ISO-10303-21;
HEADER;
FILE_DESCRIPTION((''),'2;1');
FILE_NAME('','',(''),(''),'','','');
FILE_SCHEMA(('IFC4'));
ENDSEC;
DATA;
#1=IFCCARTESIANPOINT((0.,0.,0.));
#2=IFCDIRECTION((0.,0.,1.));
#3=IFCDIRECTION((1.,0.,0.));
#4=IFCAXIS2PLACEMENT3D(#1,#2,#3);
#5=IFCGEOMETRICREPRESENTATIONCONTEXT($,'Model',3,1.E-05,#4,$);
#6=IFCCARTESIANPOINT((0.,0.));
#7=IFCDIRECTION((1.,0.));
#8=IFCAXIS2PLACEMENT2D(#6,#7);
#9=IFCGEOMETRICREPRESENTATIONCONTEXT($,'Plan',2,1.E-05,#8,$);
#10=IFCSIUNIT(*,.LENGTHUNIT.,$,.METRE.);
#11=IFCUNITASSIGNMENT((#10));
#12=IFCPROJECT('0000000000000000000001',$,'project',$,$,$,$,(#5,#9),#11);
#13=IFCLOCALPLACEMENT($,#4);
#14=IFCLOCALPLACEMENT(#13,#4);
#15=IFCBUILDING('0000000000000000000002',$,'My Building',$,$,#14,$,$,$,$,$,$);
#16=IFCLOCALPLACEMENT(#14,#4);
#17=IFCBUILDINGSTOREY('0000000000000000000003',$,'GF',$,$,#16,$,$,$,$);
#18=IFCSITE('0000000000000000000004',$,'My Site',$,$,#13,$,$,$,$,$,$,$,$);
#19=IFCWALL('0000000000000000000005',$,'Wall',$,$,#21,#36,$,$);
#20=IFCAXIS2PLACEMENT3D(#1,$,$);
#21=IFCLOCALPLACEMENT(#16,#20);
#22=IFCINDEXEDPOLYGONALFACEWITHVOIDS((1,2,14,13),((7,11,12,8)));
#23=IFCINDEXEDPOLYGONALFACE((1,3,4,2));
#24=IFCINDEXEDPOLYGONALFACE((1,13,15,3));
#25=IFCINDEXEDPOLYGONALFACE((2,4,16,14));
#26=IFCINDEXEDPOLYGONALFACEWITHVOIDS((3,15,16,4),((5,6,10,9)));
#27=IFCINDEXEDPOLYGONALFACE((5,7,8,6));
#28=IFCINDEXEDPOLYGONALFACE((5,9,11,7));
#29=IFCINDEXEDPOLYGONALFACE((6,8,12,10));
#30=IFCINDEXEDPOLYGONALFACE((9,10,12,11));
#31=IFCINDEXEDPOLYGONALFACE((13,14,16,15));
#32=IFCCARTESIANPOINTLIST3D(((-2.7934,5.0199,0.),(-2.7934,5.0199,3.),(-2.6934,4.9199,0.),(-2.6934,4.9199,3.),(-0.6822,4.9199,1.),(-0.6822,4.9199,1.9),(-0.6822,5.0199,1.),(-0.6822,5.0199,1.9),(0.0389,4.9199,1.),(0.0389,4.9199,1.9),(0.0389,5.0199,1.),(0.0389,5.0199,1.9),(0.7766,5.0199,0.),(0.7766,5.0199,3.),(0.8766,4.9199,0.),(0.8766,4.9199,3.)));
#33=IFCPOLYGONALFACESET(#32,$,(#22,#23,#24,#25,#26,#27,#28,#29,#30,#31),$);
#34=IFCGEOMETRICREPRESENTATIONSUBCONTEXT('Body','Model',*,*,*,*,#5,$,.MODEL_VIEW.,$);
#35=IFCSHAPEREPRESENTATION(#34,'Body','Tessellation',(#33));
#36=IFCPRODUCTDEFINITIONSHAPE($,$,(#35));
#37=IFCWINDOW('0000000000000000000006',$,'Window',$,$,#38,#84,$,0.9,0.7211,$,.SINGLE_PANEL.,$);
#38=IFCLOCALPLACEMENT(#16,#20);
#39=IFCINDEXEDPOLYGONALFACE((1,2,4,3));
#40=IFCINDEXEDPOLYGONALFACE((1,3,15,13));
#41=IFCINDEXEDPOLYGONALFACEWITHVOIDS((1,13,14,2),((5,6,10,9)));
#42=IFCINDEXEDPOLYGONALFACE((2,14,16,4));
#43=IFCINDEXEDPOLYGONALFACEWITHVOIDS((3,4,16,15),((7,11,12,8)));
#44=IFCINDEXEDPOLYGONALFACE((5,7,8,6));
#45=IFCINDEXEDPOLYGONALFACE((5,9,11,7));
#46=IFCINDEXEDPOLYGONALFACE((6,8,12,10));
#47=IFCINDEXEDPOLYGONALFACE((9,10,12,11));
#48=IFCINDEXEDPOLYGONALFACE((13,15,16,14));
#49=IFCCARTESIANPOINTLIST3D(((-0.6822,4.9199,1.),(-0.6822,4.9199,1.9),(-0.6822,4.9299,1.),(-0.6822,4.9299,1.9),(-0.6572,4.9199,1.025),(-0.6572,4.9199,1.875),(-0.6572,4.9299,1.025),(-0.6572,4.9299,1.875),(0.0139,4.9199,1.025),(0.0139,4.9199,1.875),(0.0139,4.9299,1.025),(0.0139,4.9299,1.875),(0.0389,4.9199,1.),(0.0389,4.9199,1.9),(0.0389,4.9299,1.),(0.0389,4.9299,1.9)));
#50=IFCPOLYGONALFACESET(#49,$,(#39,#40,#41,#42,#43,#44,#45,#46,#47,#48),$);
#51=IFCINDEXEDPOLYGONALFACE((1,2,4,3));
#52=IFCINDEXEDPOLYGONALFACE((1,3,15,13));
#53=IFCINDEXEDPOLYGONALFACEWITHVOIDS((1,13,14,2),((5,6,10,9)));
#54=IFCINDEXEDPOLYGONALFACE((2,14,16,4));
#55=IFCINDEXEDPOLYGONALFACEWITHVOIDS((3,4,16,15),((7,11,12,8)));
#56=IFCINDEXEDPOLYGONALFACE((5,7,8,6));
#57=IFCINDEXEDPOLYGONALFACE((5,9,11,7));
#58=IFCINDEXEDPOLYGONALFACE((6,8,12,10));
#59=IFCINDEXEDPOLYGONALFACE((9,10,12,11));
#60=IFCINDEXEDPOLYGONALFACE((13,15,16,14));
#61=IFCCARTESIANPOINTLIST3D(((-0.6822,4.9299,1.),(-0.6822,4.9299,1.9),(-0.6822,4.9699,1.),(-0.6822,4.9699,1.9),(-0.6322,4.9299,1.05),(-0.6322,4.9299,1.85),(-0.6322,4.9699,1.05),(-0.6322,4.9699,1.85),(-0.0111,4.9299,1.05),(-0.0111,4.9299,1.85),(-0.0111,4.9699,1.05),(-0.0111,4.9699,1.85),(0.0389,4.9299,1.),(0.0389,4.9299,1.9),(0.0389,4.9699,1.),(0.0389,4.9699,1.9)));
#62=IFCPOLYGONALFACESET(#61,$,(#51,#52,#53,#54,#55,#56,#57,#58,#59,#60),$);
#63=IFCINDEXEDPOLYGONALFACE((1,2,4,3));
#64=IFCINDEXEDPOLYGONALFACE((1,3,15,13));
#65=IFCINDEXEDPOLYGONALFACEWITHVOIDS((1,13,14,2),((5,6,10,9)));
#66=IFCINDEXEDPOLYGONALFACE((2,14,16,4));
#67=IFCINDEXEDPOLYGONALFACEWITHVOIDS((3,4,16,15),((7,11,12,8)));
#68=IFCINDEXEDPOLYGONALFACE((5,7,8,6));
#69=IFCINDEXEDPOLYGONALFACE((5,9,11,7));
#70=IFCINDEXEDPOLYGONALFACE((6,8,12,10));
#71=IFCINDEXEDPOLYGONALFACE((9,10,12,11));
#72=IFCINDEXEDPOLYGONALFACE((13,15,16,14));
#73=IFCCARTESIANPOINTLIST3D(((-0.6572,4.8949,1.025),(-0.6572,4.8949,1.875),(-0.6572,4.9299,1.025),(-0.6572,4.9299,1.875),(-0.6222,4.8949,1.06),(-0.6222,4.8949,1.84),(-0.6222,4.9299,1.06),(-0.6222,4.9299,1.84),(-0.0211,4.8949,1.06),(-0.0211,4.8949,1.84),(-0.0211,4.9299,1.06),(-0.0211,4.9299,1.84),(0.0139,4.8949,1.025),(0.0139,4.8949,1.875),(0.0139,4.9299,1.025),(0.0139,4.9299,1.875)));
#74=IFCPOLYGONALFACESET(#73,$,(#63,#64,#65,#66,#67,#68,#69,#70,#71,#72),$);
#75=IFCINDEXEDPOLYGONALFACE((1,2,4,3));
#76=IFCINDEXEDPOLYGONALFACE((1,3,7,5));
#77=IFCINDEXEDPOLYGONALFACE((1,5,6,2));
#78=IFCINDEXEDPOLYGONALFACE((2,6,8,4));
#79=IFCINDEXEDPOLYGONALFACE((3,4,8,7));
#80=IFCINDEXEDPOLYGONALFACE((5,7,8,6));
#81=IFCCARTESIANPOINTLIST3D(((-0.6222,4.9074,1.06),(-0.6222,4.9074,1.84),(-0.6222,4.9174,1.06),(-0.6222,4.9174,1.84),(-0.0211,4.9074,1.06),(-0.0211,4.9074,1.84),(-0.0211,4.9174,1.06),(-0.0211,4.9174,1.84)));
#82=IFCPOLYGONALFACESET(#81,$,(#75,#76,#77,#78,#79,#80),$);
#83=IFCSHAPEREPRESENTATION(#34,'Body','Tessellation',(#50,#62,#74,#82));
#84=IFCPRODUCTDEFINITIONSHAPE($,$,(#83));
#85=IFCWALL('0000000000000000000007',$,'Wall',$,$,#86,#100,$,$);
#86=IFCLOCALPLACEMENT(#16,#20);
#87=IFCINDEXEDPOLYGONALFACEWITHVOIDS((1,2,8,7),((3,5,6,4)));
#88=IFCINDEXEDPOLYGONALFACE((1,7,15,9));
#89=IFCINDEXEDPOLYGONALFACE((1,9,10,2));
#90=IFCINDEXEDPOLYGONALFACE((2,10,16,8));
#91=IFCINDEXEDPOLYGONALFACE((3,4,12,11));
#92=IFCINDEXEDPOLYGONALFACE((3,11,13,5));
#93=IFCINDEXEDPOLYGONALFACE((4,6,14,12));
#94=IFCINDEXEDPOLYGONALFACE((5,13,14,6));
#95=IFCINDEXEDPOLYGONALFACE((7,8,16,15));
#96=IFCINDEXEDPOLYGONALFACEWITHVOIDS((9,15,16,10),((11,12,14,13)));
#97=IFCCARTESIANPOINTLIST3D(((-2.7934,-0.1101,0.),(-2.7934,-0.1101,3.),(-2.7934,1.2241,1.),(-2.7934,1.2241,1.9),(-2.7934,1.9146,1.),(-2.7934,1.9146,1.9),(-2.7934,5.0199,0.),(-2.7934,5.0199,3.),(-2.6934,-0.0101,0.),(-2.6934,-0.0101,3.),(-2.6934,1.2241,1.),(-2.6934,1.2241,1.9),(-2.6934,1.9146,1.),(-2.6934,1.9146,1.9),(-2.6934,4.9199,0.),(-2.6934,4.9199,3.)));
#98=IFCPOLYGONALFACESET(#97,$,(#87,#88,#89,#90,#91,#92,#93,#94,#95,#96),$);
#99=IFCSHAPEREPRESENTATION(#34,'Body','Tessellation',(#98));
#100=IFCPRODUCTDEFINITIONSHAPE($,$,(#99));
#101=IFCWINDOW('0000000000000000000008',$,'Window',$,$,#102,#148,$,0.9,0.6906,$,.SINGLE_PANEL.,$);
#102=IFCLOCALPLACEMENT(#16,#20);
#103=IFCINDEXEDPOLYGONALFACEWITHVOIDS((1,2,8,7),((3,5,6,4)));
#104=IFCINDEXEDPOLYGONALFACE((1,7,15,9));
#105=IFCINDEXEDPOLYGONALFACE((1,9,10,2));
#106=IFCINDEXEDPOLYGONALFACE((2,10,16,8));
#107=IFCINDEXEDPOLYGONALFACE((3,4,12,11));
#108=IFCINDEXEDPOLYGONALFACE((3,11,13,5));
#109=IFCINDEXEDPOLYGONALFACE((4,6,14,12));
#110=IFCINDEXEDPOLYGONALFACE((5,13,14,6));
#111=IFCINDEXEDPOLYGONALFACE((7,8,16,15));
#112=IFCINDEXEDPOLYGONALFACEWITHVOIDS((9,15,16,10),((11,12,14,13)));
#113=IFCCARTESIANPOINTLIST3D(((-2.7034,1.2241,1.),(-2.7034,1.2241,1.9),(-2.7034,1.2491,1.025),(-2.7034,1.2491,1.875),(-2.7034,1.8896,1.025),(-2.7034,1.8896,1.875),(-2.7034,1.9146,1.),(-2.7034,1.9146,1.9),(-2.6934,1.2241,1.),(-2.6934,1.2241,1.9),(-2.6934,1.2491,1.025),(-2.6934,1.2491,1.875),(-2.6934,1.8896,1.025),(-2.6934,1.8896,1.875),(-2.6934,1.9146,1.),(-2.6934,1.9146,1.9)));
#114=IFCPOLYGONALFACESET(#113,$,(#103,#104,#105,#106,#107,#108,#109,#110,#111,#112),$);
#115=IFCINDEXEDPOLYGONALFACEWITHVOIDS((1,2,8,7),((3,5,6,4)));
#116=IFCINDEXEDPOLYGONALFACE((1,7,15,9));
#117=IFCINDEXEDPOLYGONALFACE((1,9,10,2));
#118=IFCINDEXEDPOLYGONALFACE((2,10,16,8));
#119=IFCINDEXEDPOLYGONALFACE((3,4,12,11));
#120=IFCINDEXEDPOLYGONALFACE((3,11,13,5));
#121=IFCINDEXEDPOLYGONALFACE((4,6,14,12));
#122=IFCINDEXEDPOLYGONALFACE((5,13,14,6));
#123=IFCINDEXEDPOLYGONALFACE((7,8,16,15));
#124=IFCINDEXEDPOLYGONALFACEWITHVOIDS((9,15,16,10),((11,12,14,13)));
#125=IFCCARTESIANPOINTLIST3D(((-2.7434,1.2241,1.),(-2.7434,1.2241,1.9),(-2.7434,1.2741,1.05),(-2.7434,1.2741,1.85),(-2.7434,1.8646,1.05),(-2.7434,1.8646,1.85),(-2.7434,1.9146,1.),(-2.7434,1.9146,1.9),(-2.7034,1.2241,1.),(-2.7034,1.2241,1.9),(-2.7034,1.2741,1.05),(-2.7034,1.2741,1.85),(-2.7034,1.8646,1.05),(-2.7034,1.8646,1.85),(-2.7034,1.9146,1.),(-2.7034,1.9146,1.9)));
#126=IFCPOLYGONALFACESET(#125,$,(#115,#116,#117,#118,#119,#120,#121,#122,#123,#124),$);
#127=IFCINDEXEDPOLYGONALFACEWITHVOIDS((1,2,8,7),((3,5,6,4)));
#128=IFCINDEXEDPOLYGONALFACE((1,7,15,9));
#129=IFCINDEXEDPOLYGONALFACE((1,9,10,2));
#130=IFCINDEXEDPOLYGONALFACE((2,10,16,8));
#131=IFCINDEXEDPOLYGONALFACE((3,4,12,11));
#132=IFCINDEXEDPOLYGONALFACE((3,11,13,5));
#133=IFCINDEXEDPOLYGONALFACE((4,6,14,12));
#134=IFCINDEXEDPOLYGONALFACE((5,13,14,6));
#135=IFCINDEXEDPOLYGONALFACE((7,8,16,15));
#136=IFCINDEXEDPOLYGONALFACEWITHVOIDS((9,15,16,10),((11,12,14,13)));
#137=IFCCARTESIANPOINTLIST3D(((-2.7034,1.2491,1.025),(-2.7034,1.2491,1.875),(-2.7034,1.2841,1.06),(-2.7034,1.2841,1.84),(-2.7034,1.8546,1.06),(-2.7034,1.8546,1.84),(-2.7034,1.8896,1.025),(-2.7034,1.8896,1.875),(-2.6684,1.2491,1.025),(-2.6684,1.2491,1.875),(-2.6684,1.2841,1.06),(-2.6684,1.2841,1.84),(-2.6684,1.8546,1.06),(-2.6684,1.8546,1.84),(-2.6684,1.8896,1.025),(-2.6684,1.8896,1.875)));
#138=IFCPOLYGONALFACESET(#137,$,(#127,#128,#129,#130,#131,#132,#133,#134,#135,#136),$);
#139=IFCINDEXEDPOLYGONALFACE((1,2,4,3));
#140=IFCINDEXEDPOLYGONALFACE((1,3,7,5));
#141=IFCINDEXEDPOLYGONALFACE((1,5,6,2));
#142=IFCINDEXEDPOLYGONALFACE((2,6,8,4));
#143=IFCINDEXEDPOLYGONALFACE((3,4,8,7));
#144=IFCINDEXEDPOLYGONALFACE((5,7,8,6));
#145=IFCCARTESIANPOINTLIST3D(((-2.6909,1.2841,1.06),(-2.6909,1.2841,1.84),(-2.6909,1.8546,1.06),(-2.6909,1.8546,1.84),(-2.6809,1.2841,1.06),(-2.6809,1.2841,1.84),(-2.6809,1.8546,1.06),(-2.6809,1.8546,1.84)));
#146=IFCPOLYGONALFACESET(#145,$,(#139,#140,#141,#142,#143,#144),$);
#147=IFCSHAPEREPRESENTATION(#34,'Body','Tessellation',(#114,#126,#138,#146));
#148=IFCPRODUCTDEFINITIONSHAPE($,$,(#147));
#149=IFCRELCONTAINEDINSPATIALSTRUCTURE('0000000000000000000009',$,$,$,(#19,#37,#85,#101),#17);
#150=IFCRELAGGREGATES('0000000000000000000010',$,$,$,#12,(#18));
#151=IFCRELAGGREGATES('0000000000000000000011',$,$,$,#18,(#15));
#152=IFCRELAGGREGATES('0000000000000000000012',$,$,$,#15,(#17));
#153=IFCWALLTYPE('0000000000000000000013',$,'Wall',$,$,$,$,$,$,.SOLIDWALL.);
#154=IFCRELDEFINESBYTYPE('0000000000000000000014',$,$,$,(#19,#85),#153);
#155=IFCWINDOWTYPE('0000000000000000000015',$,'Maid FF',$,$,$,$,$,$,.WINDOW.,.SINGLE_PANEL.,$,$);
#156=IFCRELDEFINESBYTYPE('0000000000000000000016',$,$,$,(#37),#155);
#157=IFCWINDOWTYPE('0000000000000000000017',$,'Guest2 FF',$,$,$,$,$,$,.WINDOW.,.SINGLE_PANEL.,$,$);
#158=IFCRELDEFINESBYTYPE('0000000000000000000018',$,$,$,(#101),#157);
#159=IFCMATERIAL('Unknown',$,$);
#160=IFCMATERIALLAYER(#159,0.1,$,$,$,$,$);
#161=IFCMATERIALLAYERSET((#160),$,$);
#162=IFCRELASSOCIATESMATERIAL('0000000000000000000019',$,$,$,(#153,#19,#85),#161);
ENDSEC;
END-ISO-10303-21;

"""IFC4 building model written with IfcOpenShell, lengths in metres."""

from ifc_helpers import new_model, entity, si_unit, frame, origin_with_axes, origin_2d_with_axis, place, context, subcontext, project, spatial, line, indexed_curve, outline, extrude, shape, source, transform, mapped, material, layer, layer_set, layer_usage, type_object, type_shapes, element, fill, save


model = new_model("IFC4")

# Units and contexts
model_context = context("Model", 3, precision=1e-05, world=origin_with_axes())
plan_context = context("Plan", 2, precision=1e-05, world=origin_2d_with_axis())
body_context_1 = subcontext(model_context, "Body", "Model", "MODEL_VIEW")
body_context_2 = subcontext(plan_context, "Body", "Plan", "PLAN_VIEW")
ifc_project = project(units=[si_unit("LENGTHUNIT", "METRE")], contexts=[model_context, plan_context])

# Site, building, storey
site_placement = place(None, origin_with_axes())
site = spatial("IfcSite", under=ifc_project, at=site_placement, Name="My Site")
building_placement = place(site_placement, origin_with_axes())
building = spatial("IfcBuilding", under=site, at=building_placement, Name="My Building")
storey_placement = place(building_placement, origin_with_axes())
storey = spatial("IfcBuildingStorey", under=building, at=storey_placement, Name="GF")

# Shared definitions
ifc_material = material(Name="Unknown")

# Shared definitions
ifc_layer = layer(ifc_material, 0.1)
ifc_layer_set = layer_set([ifc_layer])
wall_type = type_object("IfcWallType", Name="Wall", PredefinedType="SOLIDWALL", material=ifc_layer_set)

# Walls, openings, windows
ifc_layer_usage_1 = layer_usage(ifc_layer_set, "AXIS2", "POSITIVE", 0.0)
wall_1_placement = place(storey_placement, frame((0.7766, 5.0199, 0.0), z_axis=(0.0, 0.0, 1.0), x_axis=(-1.0, 0.0, 0.0)))
wall_1 = element("IfcWall", 1, at=wall_1_placement, inside=storey, type_object=wall_type, material=ifc_layer_usage_1, Name="Wall", context=body_context_1, shape_type="SweptSolid", body=[
    extrude(outline(indexed_curve([(0.0, 0.0), (-0.1, 0.1), (3.47, 0.1), (3.57, 0.0)], segments=[line(1, 2, 3, 4, 1)])), origin_with_axes(), (0.0, 0.0, 1.0), 3.0),
])
shared_shape_1 = source(origin_with_axes(), body_context_1, "Body", "SweptSolid", [
    extrude(outline(indexed_curve([(0.0, 0.0), (0.7211, 0.0), (0.7211, 0.9), (0.0, 0.9)], segments=[line(1, 2, 3, 4, 1)])), frame((0.0, -0.6, 0.0), z_axis=(0.0, -1.0, 0.0), x_axis=(1.0, 0.0, 0.0)), (0.0, 0.0, -1.0), 1.2),
])
opening_1_placement = place(wall_1_placement, frame((0.7377, 0.0, 1.0), z_axis=(0.0, 0.0, 1.0), x_axis=(1.0, 0.0, 0.0)))
opening_1 = element("IfcOpeningElement", 2, at=opening_1_placement, cuts=wall_1, PredefinedType="OPENING", context=body_context_1, shape_type="MappedRepresentation", body=[
    mapped(shared_shape_1, transform((0.0, 0.0, 0.0), x_axis=(1.0, 0.0, 0.0), y_axis=(0.0, 1.0, 0.0), z_axis=(0.0, 0.0, 1.0), scale=1.0)),
])
window_type_1 = type_object("IfcWindowType", Name="Maid FF", PartitioningType="SINGLE_PANEL", PredefinedType="WINDOW")
shared_shape_2 = source(origin_with_axes(), body_context_1, "Body", "SweptSolid", [
    extrude(outline(indexed_curve([(0.0, 0.0), (0.7211, 0.0), (0.7211, 0.9), (0.0, 0.9)], segments=[line(1, 2, 3, 4, 1)]), holes=[indexed_curve([(0.025, 0.025), (0.6961, 0.025), (0.6961, 0.875), (0.025, 0.875)], segments=[line(1, 2, 3, 4, 1)])]), frame((0.0, 0.09, 0.0), z_axis=(0.0, -1.0, 0.0), x_axis=(1.0, 0.0, 0.0)), (0.0, 0.0, -1.0), 0.01),
    extrude(outline(indexed_curve([(0.0, 0.0), (0.7211, 0.0), (0.7211, 0.9), (0.0, 0.9)], segments=[line(1, 2, 3, 4, 1)]), holes=[indexed_curve([(0.05, 0.05), (0.6711, 0.05), (0.6711, 0.85), (0.05, 0.85)], segments=[line(1, 2, 3, 4, 1)])]), frame((0.0, 0.05, 0.0), z_axis=(0.0, -1.0, 0.0), x_axis=(1.0, 0.0, 0.0)), (0.0, 0.0, -1.0), 0.04),
    extrude(outline(indexed_curve([(0.0, 0.0), (0.6711, 0.0), (0.6711, 0.85), (0.0, 0.85)], segments=[line(1, 2, 3, 4, 1)]), holes=[indexed_curve([(0.035, 0.035), (0.6361, 0.035), (0.6361, 0.815), (0.035, 0.815)], segments=[line(1, 2, 3, 4, 1)])]), frame((0.025, 0.09, 0.025), z_axis=(0.0, -1.0, 0.0), x_axis=(1.0, 0.0, 0.0)), (0.0, 0.0, -1.0), 0.035),
    extrude(outline(indexed_curve([(0.035, 0.035), (0.6361, 0.035), (0.6361, 0.815), (0.035, 0.815)], segments=[line(1, 2, 3, 4, 1)])), frame((0.025, 0.1025, 0.025), z_axis=(0.0, -1.0, 0.0), x_axis=(1.0, 0.0, 0.0)), (0.0, 0.0, -1.0), 0.01),
])
shared_shape_3 = source(origin_with_axes(), body_context_2, "Body", "Curve2D", [
    entity("IfcIndexedPolyCurve", entity("IfcCartesianPointList2D", [[0.05, 0.05], [0.6711, 0.05]])),
    entity("IfcIndexedPolyCurve", entity("IfcCartesianPointList2D", [[0.0, 0.1], [0.025, 0.1], [0.025, 0.09], [0.05, 0.09], [0.05, 0.05], [0.0, 0.05]]), [entity("IfcLineIndex", [1, 2, 3, 4, 5, 6, 1])]),
    entity("IfcIndexedPolyCurve", entity("IfcCartesianPointList2D", [[0.7211, 0.1], [0.6961, 0.1], [0.6961, 0.09], [0.6711, 0.09], [0.6711, 0.05], [0.7211, 0.05]]), [entity("IfcLineIndex", [1, 2, 3, 4, 5, 6, 1])]),
    entity("IfcIndexedPolyCurve", entity("IfcCartesianPointList2D", [[0.025, 0.09], [0.06, 0.09], [0.06, 0.125], [0.025, 0.125]]), [entity("IfcLineIndex", [1, 2, 3, 4, 1])]),
    entity("IfcIndexedPolyCurve", entity("IfcCartesianPointList2D", [[0.6961, 0.09], [0.6611, 0.09], [0.6611, 0.125], [0.6961, 0.125]]), [entity("IfcLineIndex", [1, 2, 3, 4, 1])]),
    entity("IfcIndexedPolyCurve", entity("IfcCartesianPointList2D", [[0.06, 0.09], [0.6611, 0.09]])),
    entity("IfcIndexedPolyCurve", entity("IfcCartesianPointList2D", [[0.06, 0.125], [0.6611, 0.125]])),
    entity("IfcIndexedPolyCurve", entity("IfcCartesianPointList2D", [[0.06, 0.1075], [0.6611, 0.1075]])),
])
type_shapes(window_type_1, [shared_shape_2, shared_shape_3])
window_1_placement = place(opening_1_placement, frame((0.0, 0.0, 0.0), z_axis=(0.0, 0.0, 1.0), x_axis=(1.0, 0.0, 0.0)))
window_1 = element("IfcWindow", 3, at=window_1_placement, inside=storey, type_object=window_type_1, Name="Window", OverallHeight=0.9, OverallWidth=0.7211, PartitioningType="SINGLE_PANEL", shapes=[
    shape(body_context_1, "Body", "MappedRepresentation", [mapped(shared_shape_2, transform((0.0, 0.0, 0.0), x_axis=(1.0, 0.0, 0.0), y_axis=(0.0, 1.0, 0.0), z_axis=(0.0, 0.0, 1.0), scale=1.0))]),
    shape(body_context_2, "Body", "MappedRepresentation", [mapped(shared_shape_3, transform((0.0, 0.0, 0.0), x_axis=(1.0, 0.0, 0.0), y_axis=(0.0, 1.0, 0.0), z_axis=(0.0, 0.0, 1.0), scale=1.0))]),
])
fill(opening_1, window_1)
ifc_layer_usage_2 = layer_usage(ifc_layer_set, "AXIS2", "POSITIVE", 0.0)
wall_2_placement = place(storey_placement, frame((-2.7934, 5.0199, 0.0), z_axis=(0.0, 0.0, 1.0), x_axis=(0.0, -1.0, 0.0)))
wall_2 = element("IfcWall", 4, at=wall_2_placement, inside=storey, type_object=wall_type, material=ifc_layer_usage_2, Name="Wall", context=body_context_1, shape_type="SweptSolid", body=[
    extrude(outline(indexed_curve([(0.0, 0.0), (0.1, 0.1), (5.03, 0.1), (5.13, 0.0)], segments=[line(1, 2, 3, 4, 1)])), origin_with_axes(), (0.0, 0.0, 1.0), 3.0),
])
shared_shape_4 = source(origin_with_axes(), body_context_1, "Body", "SweptSolid", [
    extrude(outline(indexed_curve([(0.0, 0.0), (0.6906, 0.0), (0.6906, 0.9), (0.0, 0.9)], segments=[line(1, 2, 3, 4, 1)])), frame((0.0, -0.6, 0.0), z_axis=(0.0, -1.0, 0.0), x_axis=(1.0, 0.0, 0.0)), (0.0, 0.0, -1.0), 1.2),
])
opening_2_placement = place(wall_2_placement, frame((3.1053, 0.0, 1.0), z_axis=(0.0, 0.0, 1.0), x_axis=(1.0, 0.0, 0.0)))
opening_2 = element("IfcOpeningElement", 5, at=opening_2_placement, cuts=wall_2, PredefinedType="OPENING", context=body_context_1, shape_type="MappedRepresentation", body=[
    mapped(shared_shape_4, transform((0.0, 0.0, 0.0), x_axis=(1.0, 0.0, 0.0), y_axis=(0.0, 1.0, 0.0), z_axis=(0.0, 0.0, 1.0), scale=1.0)),
])
window_type_2 = type_object("IfcWindowType", Name="Guest2 FF", PartitioningType="SINGLE_PANEL", PredefinedType="WINDOW")
shared_shape_5 = source(origin_with_axes(), body_context_1, "Body", "SweptSolid", [
    extrude(outline(indexed_curve([(0.0, 0.0), (0.6906, 0.0), (0.6906, 0.9), (0.0, 0.9)], segments=[line(1, 2, 3, 4, 1)]), holes=[indexed_curve([(0.025, 0.025), (0.6656, 0.025), (0.6656, 0.875), (0.025, 0.875)], segments=[line(1, 2, 3, 4, 1)])]), frame((0.0, 0.09, 0.0), z_axis=(0.0, -1.0, 0.0), x_axis=(1.0, 0.0, 0.0)), (0.0, 0.0, -1.0), 0.01),
    extrude(outline(indexed_curve([(0.0, 0.0), (0.6906, 0.0), (0.6906, 0.9), (0.0, 0.9)], segments=[line(1, 2, 3, 4, 1)]), holes=[indexed_curve([(0.05, 0.05), (0.6406, 0.05), (0.6406, 0.85), (0.05, 0.85)], segments=[line(1, 2, 3, 4, 1)])]), frame((0.0, 0.05, 0.0), z_axis=(0.0, -1.0, 0.0), x_axis=(1.0, 0.0, 0.0)), (0.0, 0.0, -1.0), 0.04),
    extrude(outline(indexed_curve([(0.0, 0.0), (0.6406, 0.0), (0.6406, 0.85), (0.0, 0.85)], segments=[line(1, 2, 3, 4, 1)]), holes=[indexed_curve([(0.035, 0.035), (0.6056, 0.035), (0.6056, 0.815), (0.035, 0.815)], segments=[line(1, 2, 3, 4, 1)])]), frame((0.025, 0.09, 0.025), z_axis=(0.0, -1.0, 0.0), x_axis=(1.0, 0.0, 0.0)), (0.0, 0.0, -1.0), 0.035),
    extrude(outline(indexed_curve([(0.035, 0.035), (0.6056, 0.035), (0.6056, 0.815), (0.035, 0.815)], segments=[line(1, 2, 3, 4, 1)])), frame((0.025, 0.1025, 0.025), z_axis=(0.0, -1.0, 0.0), x_axis=(1.0, 0.0, 0.0)), (0.0, 0.0, -1.0), 0.01),
])
shared_shape_6 = source(origin_with_axes(), body_context_2, "Body", "Curve2D", [
    entity("IfcIndexedPolyCurve", entity("IfcCartesianPointList2D", [[0.05, 0.05], [0.6406, 0.05]])),
    entity("IfcIndexedPolyCurve", entity("IfcCartesianPointList2D", [[0.0, 0.1], [0.025, 0.1], [0.025, 0.09], [0.05, 0.09], [0.05, 0.05], [0.0, 0.05]]), [entity("IfcLineIndex", [1, 2, 3, 4, 5, 6, 1])]),
    entity("IfcIndexedPolyCurve", entity("IfcCartesianPointList2D", [[0.6906, 0.1], [0.6656, 0.1], [0.6656, 0.09], [0.6406, 0.09], [0.6406, 0.05], [0.6906, 0.05]]), [entity("IfcLineIndex", [1, 2, 3, 4, 5, 6, 1])]),
    entity("IfcIndexedPolyCurve", entity("IfcCartesianPointList2D", [[0.025, 0.09], [0.06, 0.09], [0.06, 0.125], [0.025, 0.125]]), [entity("IfcLineIndex", [1, 2, 3, 4, 1])]),
    entity("IfcIndexedPolyCurve", entity("IfcCartesianPointList2D", [[0.6656, 0.09], [0.6306, 0.09], [0.6306, 0.125], [0.6656, 0.125]]), [entity("IfcLineIndex", [1, 2, 3, 4, 1])]),
    entity("IfcIndexedPolyCurve", entity("IfcCartesianPointList2D", [[0.06, 0.09], [0.6306, 0.09]])),
    entity("IfcIndexedPolyCurve", entity("IfcCartesianPointList2D", [[0.06, 0.125], [0.6306, 0.125]])),
    entity("IfcIndexedPolyCurve", entity("IfcCartesianPointList2D", [[0.06, 0.1075], [0.6306, 0.1075]])),
])
type_shapes(window_type_2, [shared_shape_5, shared_shape_6])
window_2_placement = place(opening_2_placement, frame((0.0, 0.0, 0.0), z_axis=(0.0, 0.0, 1.0), x_axis=(1.0, 0.0, 0.0)))
window_2 = element("IfcWindow", 6, at=window_2_placement, inside=storey, type_object=window_type_2, Name="Window", OverallHeight=0.9, OverallWidth=0.6906, PartitioningType="SINGLE_PANEL", shapes=[
    shape(body_context_1, "Body", "MappedRepresentation", [mapped(shared_shape_5, transform((0.0, 0.0, 0.0), x_axis=(1.0, 0.0, 0.0), y_axis=(0.0, 1.0, 0.0), z_axis=(0.0, 0.0, 1.0), scale=1.0))]),
    shape(body_context_2, "Body", "MappedRepresentation", [mapped(shared_shape_6, transform((0.0, 0.0, 0.0), x_axis=(1.0, 0.0, 0.0), y_axis=(0.0, 1.0, 0.0), z_axis=(0.0, 0.0, 1.0), scale=1.0))]),
])
fill(opening_2, window_2)

save(model, "model.ifc")
